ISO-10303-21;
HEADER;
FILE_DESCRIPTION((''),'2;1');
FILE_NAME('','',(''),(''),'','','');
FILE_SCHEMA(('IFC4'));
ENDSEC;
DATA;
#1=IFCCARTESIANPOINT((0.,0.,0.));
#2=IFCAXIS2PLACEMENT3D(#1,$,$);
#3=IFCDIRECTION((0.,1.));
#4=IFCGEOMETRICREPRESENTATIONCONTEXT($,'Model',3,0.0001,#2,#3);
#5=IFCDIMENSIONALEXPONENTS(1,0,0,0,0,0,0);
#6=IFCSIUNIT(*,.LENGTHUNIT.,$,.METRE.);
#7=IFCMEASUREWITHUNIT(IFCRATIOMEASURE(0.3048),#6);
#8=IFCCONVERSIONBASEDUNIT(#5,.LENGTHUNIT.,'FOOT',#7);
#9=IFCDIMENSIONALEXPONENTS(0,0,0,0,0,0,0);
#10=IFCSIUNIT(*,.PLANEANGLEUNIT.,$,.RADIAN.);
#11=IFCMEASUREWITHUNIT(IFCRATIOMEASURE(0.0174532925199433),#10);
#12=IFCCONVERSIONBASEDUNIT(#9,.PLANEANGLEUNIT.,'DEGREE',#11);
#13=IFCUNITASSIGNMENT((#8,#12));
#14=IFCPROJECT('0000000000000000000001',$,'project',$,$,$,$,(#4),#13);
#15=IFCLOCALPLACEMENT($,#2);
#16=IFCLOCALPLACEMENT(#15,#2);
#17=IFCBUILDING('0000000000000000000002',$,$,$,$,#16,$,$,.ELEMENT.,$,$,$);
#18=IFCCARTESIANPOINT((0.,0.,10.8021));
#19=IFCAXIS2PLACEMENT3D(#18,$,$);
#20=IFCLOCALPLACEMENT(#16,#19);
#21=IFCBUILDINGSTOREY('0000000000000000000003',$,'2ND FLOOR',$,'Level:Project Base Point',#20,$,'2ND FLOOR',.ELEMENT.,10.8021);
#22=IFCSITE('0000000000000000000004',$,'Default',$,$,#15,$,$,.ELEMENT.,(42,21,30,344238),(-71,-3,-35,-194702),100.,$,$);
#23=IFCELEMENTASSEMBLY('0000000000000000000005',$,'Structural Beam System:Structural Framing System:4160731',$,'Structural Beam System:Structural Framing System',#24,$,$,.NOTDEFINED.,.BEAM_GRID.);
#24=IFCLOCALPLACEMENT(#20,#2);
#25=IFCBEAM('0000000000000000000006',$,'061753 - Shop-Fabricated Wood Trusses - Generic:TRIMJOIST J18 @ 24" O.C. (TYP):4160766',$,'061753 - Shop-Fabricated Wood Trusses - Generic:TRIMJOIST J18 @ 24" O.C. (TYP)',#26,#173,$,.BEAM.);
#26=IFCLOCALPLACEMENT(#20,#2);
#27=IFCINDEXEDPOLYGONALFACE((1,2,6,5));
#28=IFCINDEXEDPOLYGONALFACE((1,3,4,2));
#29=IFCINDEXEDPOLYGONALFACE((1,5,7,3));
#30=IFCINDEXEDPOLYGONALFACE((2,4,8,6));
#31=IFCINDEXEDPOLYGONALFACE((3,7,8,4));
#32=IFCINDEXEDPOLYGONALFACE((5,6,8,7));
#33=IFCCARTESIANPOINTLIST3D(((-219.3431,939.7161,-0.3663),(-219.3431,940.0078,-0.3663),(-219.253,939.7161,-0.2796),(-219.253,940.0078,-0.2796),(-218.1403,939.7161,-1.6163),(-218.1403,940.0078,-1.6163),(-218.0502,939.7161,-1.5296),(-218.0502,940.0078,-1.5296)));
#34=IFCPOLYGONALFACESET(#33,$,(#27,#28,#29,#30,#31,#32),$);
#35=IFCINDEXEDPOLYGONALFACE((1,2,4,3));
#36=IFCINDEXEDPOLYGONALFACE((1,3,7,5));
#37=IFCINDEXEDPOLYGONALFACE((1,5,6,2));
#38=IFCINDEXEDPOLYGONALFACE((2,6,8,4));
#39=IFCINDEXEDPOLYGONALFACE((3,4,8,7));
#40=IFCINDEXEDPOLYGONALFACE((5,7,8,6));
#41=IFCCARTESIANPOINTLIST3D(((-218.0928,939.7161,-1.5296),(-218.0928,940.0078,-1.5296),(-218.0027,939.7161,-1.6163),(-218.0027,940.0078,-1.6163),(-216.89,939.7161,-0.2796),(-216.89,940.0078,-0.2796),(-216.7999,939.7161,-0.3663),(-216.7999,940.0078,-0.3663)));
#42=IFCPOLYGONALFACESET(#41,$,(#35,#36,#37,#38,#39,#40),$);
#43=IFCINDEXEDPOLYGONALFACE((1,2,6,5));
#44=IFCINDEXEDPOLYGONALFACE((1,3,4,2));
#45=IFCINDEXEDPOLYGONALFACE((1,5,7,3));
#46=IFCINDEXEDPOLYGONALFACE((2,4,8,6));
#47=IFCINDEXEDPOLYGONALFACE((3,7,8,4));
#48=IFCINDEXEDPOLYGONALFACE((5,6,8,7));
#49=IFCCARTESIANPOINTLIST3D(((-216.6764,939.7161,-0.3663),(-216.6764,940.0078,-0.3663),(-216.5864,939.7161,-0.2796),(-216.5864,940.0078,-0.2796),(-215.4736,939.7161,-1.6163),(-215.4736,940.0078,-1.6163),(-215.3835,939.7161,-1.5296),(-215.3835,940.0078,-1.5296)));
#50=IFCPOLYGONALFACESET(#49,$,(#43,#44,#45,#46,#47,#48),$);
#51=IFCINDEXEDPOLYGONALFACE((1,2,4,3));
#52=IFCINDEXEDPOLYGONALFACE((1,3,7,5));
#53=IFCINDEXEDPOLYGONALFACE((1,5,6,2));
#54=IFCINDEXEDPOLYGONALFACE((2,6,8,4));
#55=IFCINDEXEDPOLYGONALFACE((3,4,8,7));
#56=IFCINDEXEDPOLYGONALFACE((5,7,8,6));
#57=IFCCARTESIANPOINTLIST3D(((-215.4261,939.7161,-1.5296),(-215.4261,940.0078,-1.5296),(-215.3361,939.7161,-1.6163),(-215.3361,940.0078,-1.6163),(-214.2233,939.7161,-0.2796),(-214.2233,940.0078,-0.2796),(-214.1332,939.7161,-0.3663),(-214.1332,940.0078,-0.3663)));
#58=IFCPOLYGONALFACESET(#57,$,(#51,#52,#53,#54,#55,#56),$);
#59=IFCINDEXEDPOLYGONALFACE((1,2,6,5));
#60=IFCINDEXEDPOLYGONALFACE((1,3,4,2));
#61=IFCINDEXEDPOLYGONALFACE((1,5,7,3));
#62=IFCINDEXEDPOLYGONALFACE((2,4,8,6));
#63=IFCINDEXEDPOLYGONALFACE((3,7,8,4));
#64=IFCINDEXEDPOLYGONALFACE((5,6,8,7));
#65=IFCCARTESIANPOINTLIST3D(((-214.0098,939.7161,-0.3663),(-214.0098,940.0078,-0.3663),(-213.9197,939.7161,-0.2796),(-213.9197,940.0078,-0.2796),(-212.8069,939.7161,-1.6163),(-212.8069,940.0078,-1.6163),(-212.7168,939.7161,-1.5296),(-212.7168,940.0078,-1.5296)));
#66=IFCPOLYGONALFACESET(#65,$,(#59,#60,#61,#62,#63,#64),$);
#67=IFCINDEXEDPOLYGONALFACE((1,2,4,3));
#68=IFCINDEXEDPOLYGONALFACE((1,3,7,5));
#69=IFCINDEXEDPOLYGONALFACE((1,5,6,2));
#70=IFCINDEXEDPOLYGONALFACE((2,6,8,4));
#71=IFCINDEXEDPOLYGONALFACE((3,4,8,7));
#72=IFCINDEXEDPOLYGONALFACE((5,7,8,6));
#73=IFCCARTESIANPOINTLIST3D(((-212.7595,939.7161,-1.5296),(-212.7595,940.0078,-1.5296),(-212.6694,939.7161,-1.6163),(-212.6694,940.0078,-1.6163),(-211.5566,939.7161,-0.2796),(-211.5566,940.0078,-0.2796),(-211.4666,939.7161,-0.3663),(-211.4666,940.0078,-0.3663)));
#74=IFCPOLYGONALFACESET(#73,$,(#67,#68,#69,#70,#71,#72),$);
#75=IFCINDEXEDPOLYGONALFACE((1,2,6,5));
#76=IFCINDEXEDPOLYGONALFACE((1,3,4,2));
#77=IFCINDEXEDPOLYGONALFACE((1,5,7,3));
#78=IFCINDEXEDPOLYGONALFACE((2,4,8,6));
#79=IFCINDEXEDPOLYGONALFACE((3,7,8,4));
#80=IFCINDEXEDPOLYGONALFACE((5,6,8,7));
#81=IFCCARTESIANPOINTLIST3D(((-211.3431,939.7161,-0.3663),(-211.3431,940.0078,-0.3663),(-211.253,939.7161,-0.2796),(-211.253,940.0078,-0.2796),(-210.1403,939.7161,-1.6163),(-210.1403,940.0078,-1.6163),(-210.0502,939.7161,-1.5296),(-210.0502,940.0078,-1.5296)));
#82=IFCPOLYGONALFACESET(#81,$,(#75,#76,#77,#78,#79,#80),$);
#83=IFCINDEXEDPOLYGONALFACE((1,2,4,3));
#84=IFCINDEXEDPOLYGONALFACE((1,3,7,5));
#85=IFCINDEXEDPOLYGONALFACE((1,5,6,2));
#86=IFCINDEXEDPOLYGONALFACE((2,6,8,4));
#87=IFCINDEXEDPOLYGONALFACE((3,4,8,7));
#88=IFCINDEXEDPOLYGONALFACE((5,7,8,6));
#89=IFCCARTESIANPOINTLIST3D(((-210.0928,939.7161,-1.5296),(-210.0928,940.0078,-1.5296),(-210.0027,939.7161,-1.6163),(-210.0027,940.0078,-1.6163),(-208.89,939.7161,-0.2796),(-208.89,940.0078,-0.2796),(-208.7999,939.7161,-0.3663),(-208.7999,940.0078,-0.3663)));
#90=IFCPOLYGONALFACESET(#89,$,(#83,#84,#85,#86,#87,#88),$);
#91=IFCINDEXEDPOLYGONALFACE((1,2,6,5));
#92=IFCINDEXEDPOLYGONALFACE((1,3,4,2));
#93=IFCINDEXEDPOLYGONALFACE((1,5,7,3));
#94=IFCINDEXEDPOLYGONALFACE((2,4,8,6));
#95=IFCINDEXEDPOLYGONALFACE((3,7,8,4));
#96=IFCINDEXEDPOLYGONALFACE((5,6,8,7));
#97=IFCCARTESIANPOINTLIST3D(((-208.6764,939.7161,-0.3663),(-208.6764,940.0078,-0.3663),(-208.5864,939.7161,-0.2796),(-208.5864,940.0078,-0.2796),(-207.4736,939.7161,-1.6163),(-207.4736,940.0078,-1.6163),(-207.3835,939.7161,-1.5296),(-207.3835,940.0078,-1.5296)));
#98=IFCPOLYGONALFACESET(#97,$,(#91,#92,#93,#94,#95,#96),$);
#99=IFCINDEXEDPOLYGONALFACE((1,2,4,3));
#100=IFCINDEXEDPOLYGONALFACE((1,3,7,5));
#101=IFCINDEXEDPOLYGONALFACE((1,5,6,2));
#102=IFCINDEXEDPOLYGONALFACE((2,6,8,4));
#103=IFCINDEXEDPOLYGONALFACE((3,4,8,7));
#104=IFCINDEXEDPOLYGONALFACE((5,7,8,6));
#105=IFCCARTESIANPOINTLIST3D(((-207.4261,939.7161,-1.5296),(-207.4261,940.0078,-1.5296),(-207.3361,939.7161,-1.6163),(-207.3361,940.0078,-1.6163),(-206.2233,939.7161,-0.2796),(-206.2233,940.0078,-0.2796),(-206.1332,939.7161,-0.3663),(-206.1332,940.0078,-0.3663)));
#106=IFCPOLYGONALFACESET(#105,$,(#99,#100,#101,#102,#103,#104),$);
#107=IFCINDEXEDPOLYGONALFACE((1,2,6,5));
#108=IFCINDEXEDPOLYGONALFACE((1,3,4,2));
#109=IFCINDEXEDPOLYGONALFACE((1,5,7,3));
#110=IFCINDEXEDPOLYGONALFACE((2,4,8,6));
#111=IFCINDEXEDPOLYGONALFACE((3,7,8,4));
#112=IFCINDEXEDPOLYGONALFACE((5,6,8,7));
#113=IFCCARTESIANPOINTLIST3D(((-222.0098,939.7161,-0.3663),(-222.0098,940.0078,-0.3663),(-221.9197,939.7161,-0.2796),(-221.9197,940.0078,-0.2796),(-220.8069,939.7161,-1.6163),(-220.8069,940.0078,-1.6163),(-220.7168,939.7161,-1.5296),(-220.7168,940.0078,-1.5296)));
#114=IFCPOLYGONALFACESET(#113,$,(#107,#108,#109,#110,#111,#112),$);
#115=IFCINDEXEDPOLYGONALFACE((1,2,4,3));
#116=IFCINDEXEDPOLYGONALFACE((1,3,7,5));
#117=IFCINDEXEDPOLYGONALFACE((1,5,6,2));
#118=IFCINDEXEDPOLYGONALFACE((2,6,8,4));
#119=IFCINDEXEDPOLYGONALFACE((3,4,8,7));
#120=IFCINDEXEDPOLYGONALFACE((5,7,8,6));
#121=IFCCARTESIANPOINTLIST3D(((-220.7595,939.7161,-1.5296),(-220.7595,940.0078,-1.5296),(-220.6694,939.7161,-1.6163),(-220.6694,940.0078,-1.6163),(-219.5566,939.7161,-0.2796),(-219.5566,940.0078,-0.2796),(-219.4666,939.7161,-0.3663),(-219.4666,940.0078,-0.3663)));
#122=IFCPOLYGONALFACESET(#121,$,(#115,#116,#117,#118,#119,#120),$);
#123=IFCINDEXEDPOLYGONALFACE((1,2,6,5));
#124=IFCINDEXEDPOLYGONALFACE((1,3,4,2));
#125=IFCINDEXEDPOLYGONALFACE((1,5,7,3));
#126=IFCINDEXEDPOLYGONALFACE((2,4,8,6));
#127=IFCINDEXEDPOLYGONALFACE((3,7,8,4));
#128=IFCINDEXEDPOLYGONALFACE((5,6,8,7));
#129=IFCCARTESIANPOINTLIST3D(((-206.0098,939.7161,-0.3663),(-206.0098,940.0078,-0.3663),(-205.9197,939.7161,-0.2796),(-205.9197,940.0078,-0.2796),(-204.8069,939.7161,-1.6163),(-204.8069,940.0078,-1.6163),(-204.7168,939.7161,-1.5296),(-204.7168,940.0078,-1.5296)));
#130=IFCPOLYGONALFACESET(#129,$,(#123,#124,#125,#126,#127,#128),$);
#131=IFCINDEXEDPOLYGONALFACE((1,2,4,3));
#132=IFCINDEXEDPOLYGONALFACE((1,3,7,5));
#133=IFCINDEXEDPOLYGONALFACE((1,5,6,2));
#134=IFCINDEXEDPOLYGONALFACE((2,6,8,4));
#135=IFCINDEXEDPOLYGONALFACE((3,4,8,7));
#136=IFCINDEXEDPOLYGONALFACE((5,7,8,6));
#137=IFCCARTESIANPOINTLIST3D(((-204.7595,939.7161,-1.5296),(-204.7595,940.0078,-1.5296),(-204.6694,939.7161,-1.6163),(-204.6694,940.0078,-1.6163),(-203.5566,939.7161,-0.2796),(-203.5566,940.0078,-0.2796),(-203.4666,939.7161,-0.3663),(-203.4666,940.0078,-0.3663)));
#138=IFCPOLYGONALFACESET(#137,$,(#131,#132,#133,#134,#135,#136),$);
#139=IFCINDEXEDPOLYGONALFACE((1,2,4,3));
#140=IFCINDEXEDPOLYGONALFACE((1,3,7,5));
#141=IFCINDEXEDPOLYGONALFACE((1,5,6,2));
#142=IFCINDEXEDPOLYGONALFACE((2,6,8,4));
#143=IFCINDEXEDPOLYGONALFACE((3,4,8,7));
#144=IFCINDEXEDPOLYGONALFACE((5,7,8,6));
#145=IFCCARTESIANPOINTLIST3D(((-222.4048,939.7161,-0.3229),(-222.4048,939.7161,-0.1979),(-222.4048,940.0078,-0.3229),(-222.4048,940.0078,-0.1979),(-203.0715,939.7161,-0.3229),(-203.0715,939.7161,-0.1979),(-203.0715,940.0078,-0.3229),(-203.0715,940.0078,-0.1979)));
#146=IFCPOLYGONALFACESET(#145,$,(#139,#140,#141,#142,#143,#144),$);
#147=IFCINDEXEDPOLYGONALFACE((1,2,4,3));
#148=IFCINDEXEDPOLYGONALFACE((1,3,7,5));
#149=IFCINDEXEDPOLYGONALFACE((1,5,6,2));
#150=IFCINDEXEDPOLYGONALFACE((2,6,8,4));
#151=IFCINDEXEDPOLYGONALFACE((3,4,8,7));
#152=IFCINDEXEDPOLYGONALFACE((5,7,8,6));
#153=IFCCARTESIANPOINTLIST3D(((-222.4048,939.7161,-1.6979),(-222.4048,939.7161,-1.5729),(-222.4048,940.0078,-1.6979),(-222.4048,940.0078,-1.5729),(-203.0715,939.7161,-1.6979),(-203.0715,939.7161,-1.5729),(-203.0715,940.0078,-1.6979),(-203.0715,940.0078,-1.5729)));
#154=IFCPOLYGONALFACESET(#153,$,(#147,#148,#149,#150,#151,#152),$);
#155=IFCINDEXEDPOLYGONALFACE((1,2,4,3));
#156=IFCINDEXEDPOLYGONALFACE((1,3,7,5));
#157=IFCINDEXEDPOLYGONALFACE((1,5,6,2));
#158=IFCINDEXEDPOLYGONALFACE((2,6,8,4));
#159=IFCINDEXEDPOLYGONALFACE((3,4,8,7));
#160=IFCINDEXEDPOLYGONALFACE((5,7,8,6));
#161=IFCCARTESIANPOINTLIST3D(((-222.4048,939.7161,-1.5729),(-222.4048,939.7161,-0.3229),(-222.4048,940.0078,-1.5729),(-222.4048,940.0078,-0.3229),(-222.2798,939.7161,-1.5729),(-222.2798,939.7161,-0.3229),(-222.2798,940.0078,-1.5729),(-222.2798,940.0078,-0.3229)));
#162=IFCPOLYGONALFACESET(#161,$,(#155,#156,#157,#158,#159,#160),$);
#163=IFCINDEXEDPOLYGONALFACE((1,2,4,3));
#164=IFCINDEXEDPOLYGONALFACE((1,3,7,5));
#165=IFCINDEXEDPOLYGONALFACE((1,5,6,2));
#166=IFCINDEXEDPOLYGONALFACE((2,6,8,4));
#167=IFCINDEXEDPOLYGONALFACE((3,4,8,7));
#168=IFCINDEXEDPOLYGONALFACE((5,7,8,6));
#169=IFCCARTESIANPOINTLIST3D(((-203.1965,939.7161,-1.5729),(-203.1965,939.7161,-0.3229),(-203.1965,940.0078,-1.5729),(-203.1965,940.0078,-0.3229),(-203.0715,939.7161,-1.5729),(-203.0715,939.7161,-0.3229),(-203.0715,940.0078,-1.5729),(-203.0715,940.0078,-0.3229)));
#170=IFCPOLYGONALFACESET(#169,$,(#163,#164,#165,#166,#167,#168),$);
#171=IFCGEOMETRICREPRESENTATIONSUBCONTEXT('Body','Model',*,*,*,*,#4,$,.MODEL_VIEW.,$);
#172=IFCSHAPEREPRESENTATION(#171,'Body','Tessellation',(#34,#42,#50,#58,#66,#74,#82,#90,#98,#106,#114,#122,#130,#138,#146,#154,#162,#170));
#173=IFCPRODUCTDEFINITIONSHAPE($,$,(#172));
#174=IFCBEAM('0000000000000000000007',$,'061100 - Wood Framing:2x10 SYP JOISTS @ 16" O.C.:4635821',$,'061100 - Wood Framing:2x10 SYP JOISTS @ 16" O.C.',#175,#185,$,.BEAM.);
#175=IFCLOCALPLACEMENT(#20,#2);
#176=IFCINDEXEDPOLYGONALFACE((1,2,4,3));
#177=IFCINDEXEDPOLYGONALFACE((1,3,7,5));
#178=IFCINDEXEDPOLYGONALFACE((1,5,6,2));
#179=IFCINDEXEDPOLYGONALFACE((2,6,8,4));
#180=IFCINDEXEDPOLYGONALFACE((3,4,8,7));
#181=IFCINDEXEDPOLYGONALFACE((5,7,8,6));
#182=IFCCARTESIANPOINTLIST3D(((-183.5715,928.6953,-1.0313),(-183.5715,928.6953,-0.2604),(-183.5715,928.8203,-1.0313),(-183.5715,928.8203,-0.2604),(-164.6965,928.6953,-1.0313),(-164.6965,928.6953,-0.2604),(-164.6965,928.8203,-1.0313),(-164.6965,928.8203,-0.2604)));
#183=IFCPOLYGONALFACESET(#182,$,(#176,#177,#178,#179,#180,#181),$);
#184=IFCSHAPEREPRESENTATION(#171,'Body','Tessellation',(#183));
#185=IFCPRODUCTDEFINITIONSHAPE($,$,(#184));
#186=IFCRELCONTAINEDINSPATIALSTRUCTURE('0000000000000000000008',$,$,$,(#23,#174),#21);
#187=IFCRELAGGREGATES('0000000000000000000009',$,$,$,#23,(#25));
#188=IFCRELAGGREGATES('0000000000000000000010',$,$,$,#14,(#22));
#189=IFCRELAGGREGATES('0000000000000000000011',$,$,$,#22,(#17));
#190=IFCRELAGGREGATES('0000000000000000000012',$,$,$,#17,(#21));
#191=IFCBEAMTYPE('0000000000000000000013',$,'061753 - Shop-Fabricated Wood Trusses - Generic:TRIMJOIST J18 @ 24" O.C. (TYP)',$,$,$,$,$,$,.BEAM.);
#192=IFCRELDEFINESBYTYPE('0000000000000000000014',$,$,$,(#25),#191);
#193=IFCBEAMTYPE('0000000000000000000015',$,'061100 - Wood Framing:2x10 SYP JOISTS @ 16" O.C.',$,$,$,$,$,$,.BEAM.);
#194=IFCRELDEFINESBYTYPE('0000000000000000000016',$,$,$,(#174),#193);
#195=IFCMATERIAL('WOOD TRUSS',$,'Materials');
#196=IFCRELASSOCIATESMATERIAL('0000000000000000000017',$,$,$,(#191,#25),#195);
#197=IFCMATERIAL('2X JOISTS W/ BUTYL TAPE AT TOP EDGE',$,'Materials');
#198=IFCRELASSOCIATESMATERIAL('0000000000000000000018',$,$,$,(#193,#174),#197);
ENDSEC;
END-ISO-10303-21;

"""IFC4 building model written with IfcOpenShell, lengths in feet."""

from ifc_helpers import new_model, entity, si_unit, converted_unit, direction, frame, frame_2d, origin, origin_2d_with_axis, place, context, subcontext, project, spatial, rectangle, extrude, source, transform, mapped, material, material_profile, profile_set, profile_usage, type_object, type_shapes, element, aggregate, save


model = new_model("IFC4")

# Units and contexts
model_context = context("Model", 3, precision=0.0001, world=origin(), true_north=direction((0.0, 1.0)))
body_context = subcontext(model_context, "Body", "Model", "MODEL_VIEW")
ifc_project = project(units=[converted_unit("LENGTHUNIT", "FOOT", entity("IfcRatioMeasure", 0.3048), si_unit("LENGTHUNIT", "METRE"), dimensions=[1, 0, 0, 0, 0, 0, 0]), converted_unit("PLANEANGLEUNIT", "DEGREE", entity("IfcRatioMeasure", 0.0174532925199433), si_unit("PLANEANGLEUNIT", "RADIAN"), dimensions=[0, 0, 0, 0, 0, 0, 0])], contexts=[model_context])

# Site, building, storey
site_placement = place(None, origin())
site = spatial("IfcSite", under=ifc_project, at=site_placement, Name="Default", CompositionType="ELEMENT", RefLatitude=(42, 21, 30, 344238), RefLongitude=(-71, -3, -35, -194702), RefElevation=100.0)
building_placement = place(site_placement, origin())
building = spatial("IfcBuilding", under=site, at=building_placement, CompositionType="ELEMENT")
storey_placement = place(building_placement, frame((0.0, 0.0, 10.8021)))
storey = spatial("IfcBuildingStorey", under=building, at=storey_placement, Name="2ND FLOOR", ObjectType="Level:Project Base Point", LongName="2ND FLOOR", CompositionType="ELEMENT", Elevation=10.8021)

# Shared definitions
ifc_material_1 = material(Name="WOOD TRUSS", Category="Materials")
ifc_material_profile_1 = material_profile(ifc_material_1, rectangle(XDim=1.7347, YDim=0.125, at=frame_2d((0.0, 0.0), x_axis=(1.0, 0.0))), Name="TRIMJOIST J18 @ 24\" O.C. (TYP)")
ifc_material_profile_2 = material_profile(ifc_material_1, rectangle(XDim=1.7347, YDim=0.125, at=frame_2d((0.0, 0.0), x_axis=(1.0, 0.0))), Name="TRIMJOIST J18 @ 24\" O.C. (TYP)")
ifc_material_profile_3 = material_profile(ifc_material_1, rectangle(XDim=1.7347, YDim=0.125, at=frame_2d((0.0, 0.0), x_axis=(1.0, 0.0))), Name="TRIMJOIST J18 @ 24\" O.C. (TYP)")
ifc_material_profile_4 = material_profile(ifc_material_1, rectangle(XDim=1.7347, YDim=0.125, at=frame_2d((0.0, 0.0), x_axis=(1.0, 0.0))), Name="TRIMJOIST J18 @ 24\" O.C. (TYP)")
ifc_material_profile_5 = material_profile(ifc_material_1, rectangle(XDim=1.7347, YDim=0.125, at=frame_2d((0.0, 0.0), x_axis=(1.0, 0.0))), Name="TRIMJOIST J18 @ 24\" O.C. (TYP)")
ifc_material_profile_6 = material_profile(ifc_material_1, rectangle(XDim=1.7347, YDim=0.125, at=frame_2d((0.0, 0.0), x_axis=(1.0, 0.0))), Name="TRIMJOIST J18 @ 24\" O.C. (TYP)")
ifc_material_profile_7 = material_profile(ifc_material_1, rectangle(XDim=1.7347, YDim=0.125, at=frame_2d((0.0, 0.0), x_axis=(1.0, 0.0))), Name="TRIMJOIST J18 @ 24\" O.C. (TYP)")
ifc_material_profile_8 = material_profile(ifc_material_1, rectangle(XDim=1.7347, YDim=0.125, at=frame_2d((0.0, 0.0), x_axis=(1.0, 0.0))), Name="TRIMJOIST J18 @ 24\" O.C. (TYP)")
ifc_material_profile_9 = material_profile(ifc_material_1, rectangle(XDim=1.7347, YDim=0.125, at=frame_2d((0.0, 0.0), x_axis=(1.0, 0.0))), Name="TRIMJOIST J18 @ 24\" O.C. (TYP)")
ifc_material_profile_10 = material_profile(ifc_material_1, rectangle(XDim=1.7347, YDim=0.125, at=origin_2d_with_axis()), Name="TRIMJOIST J18 @ 24\" O.C. (TYP)")
ifc_material_profile_11 = material_profile(ifc_material_1, rectangle(XDim=0.125, YDim=0.2917, at=origin_2d_with_axis()), Name="TRIMJOIST J18 @ 24\" O.C. (TYP)")
ifc_material_profile_12 = material_profile(ifc_material_1, rectangle(XDim=0.125, YDim=0.2917, at=origin_2d_with_axis()), Name="TRIMJOIST J18 @ 24\" O.C. (TYP)")
ifc_material_profile_13 = material_profile(ifc_material_1, rectangle(XDim=1.25, YDim=0.2917, at=origin_2d_with_axis()), Name="TRIMJOIST J18 @ 24\" O.C. (TYP)")
ifc_material_profile_14 = material_profile(ifc_material_1, rectangle(XDim=1.25, YDim=0.2917, at=origin_2d_with_axis()), Name="TRIMJOIST J18 @ 24\" O.C. (TYP)")
ifc_profile_set_1 = profile_set([ifc_material_profile_1, ifc_material_profile_2, ifc_material_profile_3, ifc_material_profile_4, ifc_material_profile_5, ifc_material_profile_6, ifc_material_profile_7, ifc_material_profile_8, ifc_material_profile_9, ifc_material_profile_10, ifc_material_profile_11, ifc_material_profile_12, ifc_material_profile_13, ifc_material_profile_14], Name="TRIMJOIST J18 @ 24\" O.C. (TYP)")
beam_type_1 = type_object("IfcBeamType", Name="061753 - Shop-Fabricated Wood Trusses - Generic:TRIMJOIST J18 @ 24\" O.C. (TYP)", PredefinedType="BEAM", material=ifc_profile_set_1)
shared_shape_1 = source(origin(), body_context, "Body", "SweptSolid", [
    extrude(rectangle(XDim=1.7347, YDim=0.125, at=frame_2d((0.0, 0.0), x_axis=(1.0, 0.0))), frame((5.9585, -0.1458, 0.0), z_axis=(0.0, 1.0, 0.0), x_axis=(0.693383, 0.0, 0.720569)), (0.0, 0.0, 1.0), 0.2917),
    extrude(rectangle(XDim=1.7347, YDim=0.125, at=origin_2d_with_axis()), frame((4.7082, -0.1458, 0.0), z_axis=(0.0, 1.0, 0.0), x_axis=(0.693383, 0.0, -0.720569)), (0.0, 0.0, 1.0), 0.2917),
    extrude(rectangle(XDim=1.7347, YDim=0.125, at=frame_2d((0.0, 0.0), x_axis=(1.0, 0.0))), frame((3.2918, -0.1458, 0.0), z_axis=(0.0, 1.0, 0.0), x_axis=(0.693383, 0.0, 0.720569)), (0.0, 0.0, 1.0), 0.2917),
    extrude(rectangle(XDim=1.7347, YDim=0.125, at=frame_2d((0.0, 0.0), x_axis=(1.0, 0.0))), frame((2.0415, -0.1458, 0.0), z_axis=(0.0, 1.0, 0.0), x_axis=(0.693383, 0.0, -0.720569)), (0.0, 0.0, 1.0), 0.2917),
    extrude(rectangle(XDim=1.7347, YDim=0.125, at=frame_2d((0.0, 0.0), x_axis=(1.0, 0.0))), frame((0.6251, -0.1458, 0.0), z_axis=(0.0, 1.0, 0.0), x_axis=(0.693383, 0.0, 0.720569)), (0.0, 0.0, 1.0), 0.2917),
    extrude(rectangle(XDim=1.7347, YDim=0.125, at=frame_2d((0.0, 0.0), x_axis=(1.0, 0.0))), frame((-0.6251, -0.1458, 0.0), z_axis=(0.0, 1.0, 0.0), x_axis=(0.693383, 0.0, -0.720569)), (0.0, 0.0, 1.0), 0.2917),
    extrude(rectangle(XDim=1.7347, YDim=0.125, at=frame_2d((0.0, 0.0), x_axis=(1.0, 0.0))), frame((-2.0415, -0.1458, 0.0), z_axis=(0.0, 1.0, 0.0), x_axis=(0.693383, 0.0, 0.720569)), (0.0, 0.0, 1.0), 0.2917),
    extrude(rectangle(XDim=1.7347, YDim=0.125, at=origin_2d_with_axis()), frame((-3.2918, -0.1458, 0.0), z_axis=(0.0, 1.0, 0.0), x_axis=(0.693383, 0.0, -0.720569)), (0.0, 0.0, 1.0), 0.2917),
    extrude(rectangle(XDim=1.7347, YDim=0.125, at=frame_2d((0.0, 0.0), x_axis=(1.0, 0.0))), frame((-4.7082, -0.1458, 0.0), z_axis=(0.0, 1.0, 0.0), x_axis=(0.693383, 0.0, 0.720569)), (0.0, 0.0, 1.0), 0.2917),
    extrude(rectangle(XDim=1.7347, YDim=0.125, at=frame_2d((0.0, 0.0), x_axis=(1.0, 0.0))), frame((-5.9585, -0.1458, 0.0), z_axis=(0.0, 1.0, 0.0), x_axis=(0.693383, 0.0, -0.720569)), (0.0, 0.0, 1.0), 0.2917),
    extrude(rectangle(XDim=1.7347, YDim=0.125, at=frame_2d((0.0, 0.0), x_axis=(1.0, 0.0))), frame((8.6251, -0.1458, 0.0), z_axis=(0.0, 1.0, 0.0), x_axis=(0.693383, 0.0, 0.720569)), (0.0, 0.0, 1.0), 0.2917),
    extrude(rectangle(XDim=1.7347, YDim=0.125, at=origin_2d_with_axis()), frame((7.3749, -0.1458, 0.0), z_axis=(0.0, 1.0, 0.0), x_axis=(0.693383, 0.0, -0.720569)), (0.0, 0.0, 1.0), 0.2917),
    extrude(rectangle(XDim=1.7347, YDim=0.125, at=frame_2d((0.0, 0.0), x_axis=(1.0, 0.0))), frame((-7.3749, -0.1458, 0.0), z_axis=(0.0, 1.0, 0.0), x_axis=(0.693383, 0.0, 0.720569)), (0.0, 0.0, 1.0), 0.2917),
    extrude(rectangle(XDim=1.7347, YDim=0.125, at=origin_2d_with_axis()), frame((-8.6251, -0.1458, 0.0), z_axis=(0.0, 1.0, 0.0), x_axis=(0.693383, 0.0, -0.720569)), (0.0, 0.0, 1.0), 0.2917),
    extrude(rectangle(XDim=0.125, YDim=0.2917, at=origin_2d_with_axis()), frame((-9.6667, 0.0, 0.6875), z_axis=(1.0, 0.0, 0.0), x_axis=(0.0, 0.0, -1.0)), (0.0, 0.0, 1.0), 19.3333),
    extrude(rectangle(XDim=0.125, YDim=0.2917, at=origin_2d_with_axis()), frame((-9.6667, 0.0, -0.6875), z_axis=(1.0, 0.0, 0.0), x_axis=(0.0, 0.0, -1.0)), (0.0, 0.0, 1.0), 19.3333),
    extrude(rectangle(XDim=1.25, YDim=0.2917, at=origin_2d_with_axis()), frame((9.5417, 0.0, 0.0), z_axis=(1.0, 0.0, 0.0), x_axis=(0.0, 0.0, -1.0)), (0.0, 0.0, 1.0), 0.125),
    extrude(rectangle(XDim=1.25, YDim=0.2917, at=origin_2d_with_axis()), frame((-9.6667, 0.0, 0.0), z_axis=(1.0, 0.0, 0.0), x_axis=(0.0, 0.0, -1.0)), (0.0, 0.0, 1.0), 0.125),
])
type_shapes(beam_type_1, [shared_shape_1])

# Element assembly, beam
assembly_1_placement = place(storey_placement, origin())
assembly_1 = element("IfcElementAssembly", 1, at=assembly_1_placement, inside=storey, Name="Structural Beam System:Structural Framing System:4160731", ObjectType="Structural Beam System:Structural Framing System", AssemblyPlace="NOTDEFINED", PredefinedType="BEAM_GRID")
ifc_profile_usage_1 = profile_usage(ifc_profile_set_1, cardinal=8)
beam_1_placement = place(assembly_1_placement, frame((-212.7382, 939.8619, -0.9479), z_axis=(0.0, 0.0, 1.0), x_axis=(-1.0, 0.0, 0.0)))
beam_1 = element("IfcBeam", 2, at=beam_1_placement, type_object=beam_type_1, material=ifc_profile_usage_1, Name="061753 - Shop-Fabricated Wood Trusses - Generic:TRIMJOIST J18 @ 24\" O.C. (TYP):4160766", ObjectType="061753 - Shop-Fabricated Wood Trusses - Generic:TRIMJOIST J18 @ 24\" O.C. (TYP)", PredefinedType="BEAM", context=body_context, shape_type="MappedRepresentation", body=[
    mapped(shared_shape_1, transform((0.0, 0.0, 0.0), scale=1.0)),
])
aggregate(assembly_1, [beam_1])

# Beam
ifc_material_2 = material(Name="2X JOISTS W/ BUTYL TAPE AT TOP EDGE", Category="Materials")
ifc_material_profile_15 = material_profile(ifc_material_2, rectangle(XDim=0.7708, YDim=0.125, at=frame_2d((0.0, 0.0), x_axis=(1.0, 0.0))), Name="2x10 SYP JOISTS @ 16\" O.C.")
ifc_profile_set_2 = profile_set([ifc_material_profile_15], Name="2x10 SYP JOISTS @ 16\" O.C.")
ifc_profile_usage_2 = profile_usage(ifc_profile_set_2, cardinal=8)
beam_type_2 = type_object("IfcBeamType", Name="061100 - Wood Framing:2x10 SYP JOISTS @ 16\" O.C.", PredefinedType="BEAM", material=ifc_profile_set_2)
shared_shape_2 = source(origin(), body_context, "Body", "SweptSolid", [
    extrude(rectangle(XDim=0.7708, YDim=0.125, at=frame_2d((0.0, 0.0), x_axis=(1.0, 0.0))), frame((-9.5, 0.0, 0.0), z_axis=(1.0, 0.0, 0.0), x_axis=(0.0, 0.0, -1.0)), (0.0, 0.0, 1.0), 18.875),
])
type_shapes(beam_type_2, [shared_shape_2])
beam_2_placement = place(storey_placement, frame((-174.0715, 928.7578, -0.6458)))
element("IfcBeam", 3, at=beam_2_placement, inside=storey, type_object=beam_type_2, material=ifc_profile_usage_2, Name="061100 - Wood Framing:2x10 SYP JOISTS @ 16\" O.C.:4635821", ObjectType="061100 - Wood Framing:2x10 SYP JOISTS @ 16\" O.C.", PredefinedType="BEAM", context=body_context, shape_type="MappedRepresentation", body=[
    mapped(shared_shape_2, transform((0.0, 0.0, 0.0), scale=1.0)),
])

save(model, "model.ifc")
